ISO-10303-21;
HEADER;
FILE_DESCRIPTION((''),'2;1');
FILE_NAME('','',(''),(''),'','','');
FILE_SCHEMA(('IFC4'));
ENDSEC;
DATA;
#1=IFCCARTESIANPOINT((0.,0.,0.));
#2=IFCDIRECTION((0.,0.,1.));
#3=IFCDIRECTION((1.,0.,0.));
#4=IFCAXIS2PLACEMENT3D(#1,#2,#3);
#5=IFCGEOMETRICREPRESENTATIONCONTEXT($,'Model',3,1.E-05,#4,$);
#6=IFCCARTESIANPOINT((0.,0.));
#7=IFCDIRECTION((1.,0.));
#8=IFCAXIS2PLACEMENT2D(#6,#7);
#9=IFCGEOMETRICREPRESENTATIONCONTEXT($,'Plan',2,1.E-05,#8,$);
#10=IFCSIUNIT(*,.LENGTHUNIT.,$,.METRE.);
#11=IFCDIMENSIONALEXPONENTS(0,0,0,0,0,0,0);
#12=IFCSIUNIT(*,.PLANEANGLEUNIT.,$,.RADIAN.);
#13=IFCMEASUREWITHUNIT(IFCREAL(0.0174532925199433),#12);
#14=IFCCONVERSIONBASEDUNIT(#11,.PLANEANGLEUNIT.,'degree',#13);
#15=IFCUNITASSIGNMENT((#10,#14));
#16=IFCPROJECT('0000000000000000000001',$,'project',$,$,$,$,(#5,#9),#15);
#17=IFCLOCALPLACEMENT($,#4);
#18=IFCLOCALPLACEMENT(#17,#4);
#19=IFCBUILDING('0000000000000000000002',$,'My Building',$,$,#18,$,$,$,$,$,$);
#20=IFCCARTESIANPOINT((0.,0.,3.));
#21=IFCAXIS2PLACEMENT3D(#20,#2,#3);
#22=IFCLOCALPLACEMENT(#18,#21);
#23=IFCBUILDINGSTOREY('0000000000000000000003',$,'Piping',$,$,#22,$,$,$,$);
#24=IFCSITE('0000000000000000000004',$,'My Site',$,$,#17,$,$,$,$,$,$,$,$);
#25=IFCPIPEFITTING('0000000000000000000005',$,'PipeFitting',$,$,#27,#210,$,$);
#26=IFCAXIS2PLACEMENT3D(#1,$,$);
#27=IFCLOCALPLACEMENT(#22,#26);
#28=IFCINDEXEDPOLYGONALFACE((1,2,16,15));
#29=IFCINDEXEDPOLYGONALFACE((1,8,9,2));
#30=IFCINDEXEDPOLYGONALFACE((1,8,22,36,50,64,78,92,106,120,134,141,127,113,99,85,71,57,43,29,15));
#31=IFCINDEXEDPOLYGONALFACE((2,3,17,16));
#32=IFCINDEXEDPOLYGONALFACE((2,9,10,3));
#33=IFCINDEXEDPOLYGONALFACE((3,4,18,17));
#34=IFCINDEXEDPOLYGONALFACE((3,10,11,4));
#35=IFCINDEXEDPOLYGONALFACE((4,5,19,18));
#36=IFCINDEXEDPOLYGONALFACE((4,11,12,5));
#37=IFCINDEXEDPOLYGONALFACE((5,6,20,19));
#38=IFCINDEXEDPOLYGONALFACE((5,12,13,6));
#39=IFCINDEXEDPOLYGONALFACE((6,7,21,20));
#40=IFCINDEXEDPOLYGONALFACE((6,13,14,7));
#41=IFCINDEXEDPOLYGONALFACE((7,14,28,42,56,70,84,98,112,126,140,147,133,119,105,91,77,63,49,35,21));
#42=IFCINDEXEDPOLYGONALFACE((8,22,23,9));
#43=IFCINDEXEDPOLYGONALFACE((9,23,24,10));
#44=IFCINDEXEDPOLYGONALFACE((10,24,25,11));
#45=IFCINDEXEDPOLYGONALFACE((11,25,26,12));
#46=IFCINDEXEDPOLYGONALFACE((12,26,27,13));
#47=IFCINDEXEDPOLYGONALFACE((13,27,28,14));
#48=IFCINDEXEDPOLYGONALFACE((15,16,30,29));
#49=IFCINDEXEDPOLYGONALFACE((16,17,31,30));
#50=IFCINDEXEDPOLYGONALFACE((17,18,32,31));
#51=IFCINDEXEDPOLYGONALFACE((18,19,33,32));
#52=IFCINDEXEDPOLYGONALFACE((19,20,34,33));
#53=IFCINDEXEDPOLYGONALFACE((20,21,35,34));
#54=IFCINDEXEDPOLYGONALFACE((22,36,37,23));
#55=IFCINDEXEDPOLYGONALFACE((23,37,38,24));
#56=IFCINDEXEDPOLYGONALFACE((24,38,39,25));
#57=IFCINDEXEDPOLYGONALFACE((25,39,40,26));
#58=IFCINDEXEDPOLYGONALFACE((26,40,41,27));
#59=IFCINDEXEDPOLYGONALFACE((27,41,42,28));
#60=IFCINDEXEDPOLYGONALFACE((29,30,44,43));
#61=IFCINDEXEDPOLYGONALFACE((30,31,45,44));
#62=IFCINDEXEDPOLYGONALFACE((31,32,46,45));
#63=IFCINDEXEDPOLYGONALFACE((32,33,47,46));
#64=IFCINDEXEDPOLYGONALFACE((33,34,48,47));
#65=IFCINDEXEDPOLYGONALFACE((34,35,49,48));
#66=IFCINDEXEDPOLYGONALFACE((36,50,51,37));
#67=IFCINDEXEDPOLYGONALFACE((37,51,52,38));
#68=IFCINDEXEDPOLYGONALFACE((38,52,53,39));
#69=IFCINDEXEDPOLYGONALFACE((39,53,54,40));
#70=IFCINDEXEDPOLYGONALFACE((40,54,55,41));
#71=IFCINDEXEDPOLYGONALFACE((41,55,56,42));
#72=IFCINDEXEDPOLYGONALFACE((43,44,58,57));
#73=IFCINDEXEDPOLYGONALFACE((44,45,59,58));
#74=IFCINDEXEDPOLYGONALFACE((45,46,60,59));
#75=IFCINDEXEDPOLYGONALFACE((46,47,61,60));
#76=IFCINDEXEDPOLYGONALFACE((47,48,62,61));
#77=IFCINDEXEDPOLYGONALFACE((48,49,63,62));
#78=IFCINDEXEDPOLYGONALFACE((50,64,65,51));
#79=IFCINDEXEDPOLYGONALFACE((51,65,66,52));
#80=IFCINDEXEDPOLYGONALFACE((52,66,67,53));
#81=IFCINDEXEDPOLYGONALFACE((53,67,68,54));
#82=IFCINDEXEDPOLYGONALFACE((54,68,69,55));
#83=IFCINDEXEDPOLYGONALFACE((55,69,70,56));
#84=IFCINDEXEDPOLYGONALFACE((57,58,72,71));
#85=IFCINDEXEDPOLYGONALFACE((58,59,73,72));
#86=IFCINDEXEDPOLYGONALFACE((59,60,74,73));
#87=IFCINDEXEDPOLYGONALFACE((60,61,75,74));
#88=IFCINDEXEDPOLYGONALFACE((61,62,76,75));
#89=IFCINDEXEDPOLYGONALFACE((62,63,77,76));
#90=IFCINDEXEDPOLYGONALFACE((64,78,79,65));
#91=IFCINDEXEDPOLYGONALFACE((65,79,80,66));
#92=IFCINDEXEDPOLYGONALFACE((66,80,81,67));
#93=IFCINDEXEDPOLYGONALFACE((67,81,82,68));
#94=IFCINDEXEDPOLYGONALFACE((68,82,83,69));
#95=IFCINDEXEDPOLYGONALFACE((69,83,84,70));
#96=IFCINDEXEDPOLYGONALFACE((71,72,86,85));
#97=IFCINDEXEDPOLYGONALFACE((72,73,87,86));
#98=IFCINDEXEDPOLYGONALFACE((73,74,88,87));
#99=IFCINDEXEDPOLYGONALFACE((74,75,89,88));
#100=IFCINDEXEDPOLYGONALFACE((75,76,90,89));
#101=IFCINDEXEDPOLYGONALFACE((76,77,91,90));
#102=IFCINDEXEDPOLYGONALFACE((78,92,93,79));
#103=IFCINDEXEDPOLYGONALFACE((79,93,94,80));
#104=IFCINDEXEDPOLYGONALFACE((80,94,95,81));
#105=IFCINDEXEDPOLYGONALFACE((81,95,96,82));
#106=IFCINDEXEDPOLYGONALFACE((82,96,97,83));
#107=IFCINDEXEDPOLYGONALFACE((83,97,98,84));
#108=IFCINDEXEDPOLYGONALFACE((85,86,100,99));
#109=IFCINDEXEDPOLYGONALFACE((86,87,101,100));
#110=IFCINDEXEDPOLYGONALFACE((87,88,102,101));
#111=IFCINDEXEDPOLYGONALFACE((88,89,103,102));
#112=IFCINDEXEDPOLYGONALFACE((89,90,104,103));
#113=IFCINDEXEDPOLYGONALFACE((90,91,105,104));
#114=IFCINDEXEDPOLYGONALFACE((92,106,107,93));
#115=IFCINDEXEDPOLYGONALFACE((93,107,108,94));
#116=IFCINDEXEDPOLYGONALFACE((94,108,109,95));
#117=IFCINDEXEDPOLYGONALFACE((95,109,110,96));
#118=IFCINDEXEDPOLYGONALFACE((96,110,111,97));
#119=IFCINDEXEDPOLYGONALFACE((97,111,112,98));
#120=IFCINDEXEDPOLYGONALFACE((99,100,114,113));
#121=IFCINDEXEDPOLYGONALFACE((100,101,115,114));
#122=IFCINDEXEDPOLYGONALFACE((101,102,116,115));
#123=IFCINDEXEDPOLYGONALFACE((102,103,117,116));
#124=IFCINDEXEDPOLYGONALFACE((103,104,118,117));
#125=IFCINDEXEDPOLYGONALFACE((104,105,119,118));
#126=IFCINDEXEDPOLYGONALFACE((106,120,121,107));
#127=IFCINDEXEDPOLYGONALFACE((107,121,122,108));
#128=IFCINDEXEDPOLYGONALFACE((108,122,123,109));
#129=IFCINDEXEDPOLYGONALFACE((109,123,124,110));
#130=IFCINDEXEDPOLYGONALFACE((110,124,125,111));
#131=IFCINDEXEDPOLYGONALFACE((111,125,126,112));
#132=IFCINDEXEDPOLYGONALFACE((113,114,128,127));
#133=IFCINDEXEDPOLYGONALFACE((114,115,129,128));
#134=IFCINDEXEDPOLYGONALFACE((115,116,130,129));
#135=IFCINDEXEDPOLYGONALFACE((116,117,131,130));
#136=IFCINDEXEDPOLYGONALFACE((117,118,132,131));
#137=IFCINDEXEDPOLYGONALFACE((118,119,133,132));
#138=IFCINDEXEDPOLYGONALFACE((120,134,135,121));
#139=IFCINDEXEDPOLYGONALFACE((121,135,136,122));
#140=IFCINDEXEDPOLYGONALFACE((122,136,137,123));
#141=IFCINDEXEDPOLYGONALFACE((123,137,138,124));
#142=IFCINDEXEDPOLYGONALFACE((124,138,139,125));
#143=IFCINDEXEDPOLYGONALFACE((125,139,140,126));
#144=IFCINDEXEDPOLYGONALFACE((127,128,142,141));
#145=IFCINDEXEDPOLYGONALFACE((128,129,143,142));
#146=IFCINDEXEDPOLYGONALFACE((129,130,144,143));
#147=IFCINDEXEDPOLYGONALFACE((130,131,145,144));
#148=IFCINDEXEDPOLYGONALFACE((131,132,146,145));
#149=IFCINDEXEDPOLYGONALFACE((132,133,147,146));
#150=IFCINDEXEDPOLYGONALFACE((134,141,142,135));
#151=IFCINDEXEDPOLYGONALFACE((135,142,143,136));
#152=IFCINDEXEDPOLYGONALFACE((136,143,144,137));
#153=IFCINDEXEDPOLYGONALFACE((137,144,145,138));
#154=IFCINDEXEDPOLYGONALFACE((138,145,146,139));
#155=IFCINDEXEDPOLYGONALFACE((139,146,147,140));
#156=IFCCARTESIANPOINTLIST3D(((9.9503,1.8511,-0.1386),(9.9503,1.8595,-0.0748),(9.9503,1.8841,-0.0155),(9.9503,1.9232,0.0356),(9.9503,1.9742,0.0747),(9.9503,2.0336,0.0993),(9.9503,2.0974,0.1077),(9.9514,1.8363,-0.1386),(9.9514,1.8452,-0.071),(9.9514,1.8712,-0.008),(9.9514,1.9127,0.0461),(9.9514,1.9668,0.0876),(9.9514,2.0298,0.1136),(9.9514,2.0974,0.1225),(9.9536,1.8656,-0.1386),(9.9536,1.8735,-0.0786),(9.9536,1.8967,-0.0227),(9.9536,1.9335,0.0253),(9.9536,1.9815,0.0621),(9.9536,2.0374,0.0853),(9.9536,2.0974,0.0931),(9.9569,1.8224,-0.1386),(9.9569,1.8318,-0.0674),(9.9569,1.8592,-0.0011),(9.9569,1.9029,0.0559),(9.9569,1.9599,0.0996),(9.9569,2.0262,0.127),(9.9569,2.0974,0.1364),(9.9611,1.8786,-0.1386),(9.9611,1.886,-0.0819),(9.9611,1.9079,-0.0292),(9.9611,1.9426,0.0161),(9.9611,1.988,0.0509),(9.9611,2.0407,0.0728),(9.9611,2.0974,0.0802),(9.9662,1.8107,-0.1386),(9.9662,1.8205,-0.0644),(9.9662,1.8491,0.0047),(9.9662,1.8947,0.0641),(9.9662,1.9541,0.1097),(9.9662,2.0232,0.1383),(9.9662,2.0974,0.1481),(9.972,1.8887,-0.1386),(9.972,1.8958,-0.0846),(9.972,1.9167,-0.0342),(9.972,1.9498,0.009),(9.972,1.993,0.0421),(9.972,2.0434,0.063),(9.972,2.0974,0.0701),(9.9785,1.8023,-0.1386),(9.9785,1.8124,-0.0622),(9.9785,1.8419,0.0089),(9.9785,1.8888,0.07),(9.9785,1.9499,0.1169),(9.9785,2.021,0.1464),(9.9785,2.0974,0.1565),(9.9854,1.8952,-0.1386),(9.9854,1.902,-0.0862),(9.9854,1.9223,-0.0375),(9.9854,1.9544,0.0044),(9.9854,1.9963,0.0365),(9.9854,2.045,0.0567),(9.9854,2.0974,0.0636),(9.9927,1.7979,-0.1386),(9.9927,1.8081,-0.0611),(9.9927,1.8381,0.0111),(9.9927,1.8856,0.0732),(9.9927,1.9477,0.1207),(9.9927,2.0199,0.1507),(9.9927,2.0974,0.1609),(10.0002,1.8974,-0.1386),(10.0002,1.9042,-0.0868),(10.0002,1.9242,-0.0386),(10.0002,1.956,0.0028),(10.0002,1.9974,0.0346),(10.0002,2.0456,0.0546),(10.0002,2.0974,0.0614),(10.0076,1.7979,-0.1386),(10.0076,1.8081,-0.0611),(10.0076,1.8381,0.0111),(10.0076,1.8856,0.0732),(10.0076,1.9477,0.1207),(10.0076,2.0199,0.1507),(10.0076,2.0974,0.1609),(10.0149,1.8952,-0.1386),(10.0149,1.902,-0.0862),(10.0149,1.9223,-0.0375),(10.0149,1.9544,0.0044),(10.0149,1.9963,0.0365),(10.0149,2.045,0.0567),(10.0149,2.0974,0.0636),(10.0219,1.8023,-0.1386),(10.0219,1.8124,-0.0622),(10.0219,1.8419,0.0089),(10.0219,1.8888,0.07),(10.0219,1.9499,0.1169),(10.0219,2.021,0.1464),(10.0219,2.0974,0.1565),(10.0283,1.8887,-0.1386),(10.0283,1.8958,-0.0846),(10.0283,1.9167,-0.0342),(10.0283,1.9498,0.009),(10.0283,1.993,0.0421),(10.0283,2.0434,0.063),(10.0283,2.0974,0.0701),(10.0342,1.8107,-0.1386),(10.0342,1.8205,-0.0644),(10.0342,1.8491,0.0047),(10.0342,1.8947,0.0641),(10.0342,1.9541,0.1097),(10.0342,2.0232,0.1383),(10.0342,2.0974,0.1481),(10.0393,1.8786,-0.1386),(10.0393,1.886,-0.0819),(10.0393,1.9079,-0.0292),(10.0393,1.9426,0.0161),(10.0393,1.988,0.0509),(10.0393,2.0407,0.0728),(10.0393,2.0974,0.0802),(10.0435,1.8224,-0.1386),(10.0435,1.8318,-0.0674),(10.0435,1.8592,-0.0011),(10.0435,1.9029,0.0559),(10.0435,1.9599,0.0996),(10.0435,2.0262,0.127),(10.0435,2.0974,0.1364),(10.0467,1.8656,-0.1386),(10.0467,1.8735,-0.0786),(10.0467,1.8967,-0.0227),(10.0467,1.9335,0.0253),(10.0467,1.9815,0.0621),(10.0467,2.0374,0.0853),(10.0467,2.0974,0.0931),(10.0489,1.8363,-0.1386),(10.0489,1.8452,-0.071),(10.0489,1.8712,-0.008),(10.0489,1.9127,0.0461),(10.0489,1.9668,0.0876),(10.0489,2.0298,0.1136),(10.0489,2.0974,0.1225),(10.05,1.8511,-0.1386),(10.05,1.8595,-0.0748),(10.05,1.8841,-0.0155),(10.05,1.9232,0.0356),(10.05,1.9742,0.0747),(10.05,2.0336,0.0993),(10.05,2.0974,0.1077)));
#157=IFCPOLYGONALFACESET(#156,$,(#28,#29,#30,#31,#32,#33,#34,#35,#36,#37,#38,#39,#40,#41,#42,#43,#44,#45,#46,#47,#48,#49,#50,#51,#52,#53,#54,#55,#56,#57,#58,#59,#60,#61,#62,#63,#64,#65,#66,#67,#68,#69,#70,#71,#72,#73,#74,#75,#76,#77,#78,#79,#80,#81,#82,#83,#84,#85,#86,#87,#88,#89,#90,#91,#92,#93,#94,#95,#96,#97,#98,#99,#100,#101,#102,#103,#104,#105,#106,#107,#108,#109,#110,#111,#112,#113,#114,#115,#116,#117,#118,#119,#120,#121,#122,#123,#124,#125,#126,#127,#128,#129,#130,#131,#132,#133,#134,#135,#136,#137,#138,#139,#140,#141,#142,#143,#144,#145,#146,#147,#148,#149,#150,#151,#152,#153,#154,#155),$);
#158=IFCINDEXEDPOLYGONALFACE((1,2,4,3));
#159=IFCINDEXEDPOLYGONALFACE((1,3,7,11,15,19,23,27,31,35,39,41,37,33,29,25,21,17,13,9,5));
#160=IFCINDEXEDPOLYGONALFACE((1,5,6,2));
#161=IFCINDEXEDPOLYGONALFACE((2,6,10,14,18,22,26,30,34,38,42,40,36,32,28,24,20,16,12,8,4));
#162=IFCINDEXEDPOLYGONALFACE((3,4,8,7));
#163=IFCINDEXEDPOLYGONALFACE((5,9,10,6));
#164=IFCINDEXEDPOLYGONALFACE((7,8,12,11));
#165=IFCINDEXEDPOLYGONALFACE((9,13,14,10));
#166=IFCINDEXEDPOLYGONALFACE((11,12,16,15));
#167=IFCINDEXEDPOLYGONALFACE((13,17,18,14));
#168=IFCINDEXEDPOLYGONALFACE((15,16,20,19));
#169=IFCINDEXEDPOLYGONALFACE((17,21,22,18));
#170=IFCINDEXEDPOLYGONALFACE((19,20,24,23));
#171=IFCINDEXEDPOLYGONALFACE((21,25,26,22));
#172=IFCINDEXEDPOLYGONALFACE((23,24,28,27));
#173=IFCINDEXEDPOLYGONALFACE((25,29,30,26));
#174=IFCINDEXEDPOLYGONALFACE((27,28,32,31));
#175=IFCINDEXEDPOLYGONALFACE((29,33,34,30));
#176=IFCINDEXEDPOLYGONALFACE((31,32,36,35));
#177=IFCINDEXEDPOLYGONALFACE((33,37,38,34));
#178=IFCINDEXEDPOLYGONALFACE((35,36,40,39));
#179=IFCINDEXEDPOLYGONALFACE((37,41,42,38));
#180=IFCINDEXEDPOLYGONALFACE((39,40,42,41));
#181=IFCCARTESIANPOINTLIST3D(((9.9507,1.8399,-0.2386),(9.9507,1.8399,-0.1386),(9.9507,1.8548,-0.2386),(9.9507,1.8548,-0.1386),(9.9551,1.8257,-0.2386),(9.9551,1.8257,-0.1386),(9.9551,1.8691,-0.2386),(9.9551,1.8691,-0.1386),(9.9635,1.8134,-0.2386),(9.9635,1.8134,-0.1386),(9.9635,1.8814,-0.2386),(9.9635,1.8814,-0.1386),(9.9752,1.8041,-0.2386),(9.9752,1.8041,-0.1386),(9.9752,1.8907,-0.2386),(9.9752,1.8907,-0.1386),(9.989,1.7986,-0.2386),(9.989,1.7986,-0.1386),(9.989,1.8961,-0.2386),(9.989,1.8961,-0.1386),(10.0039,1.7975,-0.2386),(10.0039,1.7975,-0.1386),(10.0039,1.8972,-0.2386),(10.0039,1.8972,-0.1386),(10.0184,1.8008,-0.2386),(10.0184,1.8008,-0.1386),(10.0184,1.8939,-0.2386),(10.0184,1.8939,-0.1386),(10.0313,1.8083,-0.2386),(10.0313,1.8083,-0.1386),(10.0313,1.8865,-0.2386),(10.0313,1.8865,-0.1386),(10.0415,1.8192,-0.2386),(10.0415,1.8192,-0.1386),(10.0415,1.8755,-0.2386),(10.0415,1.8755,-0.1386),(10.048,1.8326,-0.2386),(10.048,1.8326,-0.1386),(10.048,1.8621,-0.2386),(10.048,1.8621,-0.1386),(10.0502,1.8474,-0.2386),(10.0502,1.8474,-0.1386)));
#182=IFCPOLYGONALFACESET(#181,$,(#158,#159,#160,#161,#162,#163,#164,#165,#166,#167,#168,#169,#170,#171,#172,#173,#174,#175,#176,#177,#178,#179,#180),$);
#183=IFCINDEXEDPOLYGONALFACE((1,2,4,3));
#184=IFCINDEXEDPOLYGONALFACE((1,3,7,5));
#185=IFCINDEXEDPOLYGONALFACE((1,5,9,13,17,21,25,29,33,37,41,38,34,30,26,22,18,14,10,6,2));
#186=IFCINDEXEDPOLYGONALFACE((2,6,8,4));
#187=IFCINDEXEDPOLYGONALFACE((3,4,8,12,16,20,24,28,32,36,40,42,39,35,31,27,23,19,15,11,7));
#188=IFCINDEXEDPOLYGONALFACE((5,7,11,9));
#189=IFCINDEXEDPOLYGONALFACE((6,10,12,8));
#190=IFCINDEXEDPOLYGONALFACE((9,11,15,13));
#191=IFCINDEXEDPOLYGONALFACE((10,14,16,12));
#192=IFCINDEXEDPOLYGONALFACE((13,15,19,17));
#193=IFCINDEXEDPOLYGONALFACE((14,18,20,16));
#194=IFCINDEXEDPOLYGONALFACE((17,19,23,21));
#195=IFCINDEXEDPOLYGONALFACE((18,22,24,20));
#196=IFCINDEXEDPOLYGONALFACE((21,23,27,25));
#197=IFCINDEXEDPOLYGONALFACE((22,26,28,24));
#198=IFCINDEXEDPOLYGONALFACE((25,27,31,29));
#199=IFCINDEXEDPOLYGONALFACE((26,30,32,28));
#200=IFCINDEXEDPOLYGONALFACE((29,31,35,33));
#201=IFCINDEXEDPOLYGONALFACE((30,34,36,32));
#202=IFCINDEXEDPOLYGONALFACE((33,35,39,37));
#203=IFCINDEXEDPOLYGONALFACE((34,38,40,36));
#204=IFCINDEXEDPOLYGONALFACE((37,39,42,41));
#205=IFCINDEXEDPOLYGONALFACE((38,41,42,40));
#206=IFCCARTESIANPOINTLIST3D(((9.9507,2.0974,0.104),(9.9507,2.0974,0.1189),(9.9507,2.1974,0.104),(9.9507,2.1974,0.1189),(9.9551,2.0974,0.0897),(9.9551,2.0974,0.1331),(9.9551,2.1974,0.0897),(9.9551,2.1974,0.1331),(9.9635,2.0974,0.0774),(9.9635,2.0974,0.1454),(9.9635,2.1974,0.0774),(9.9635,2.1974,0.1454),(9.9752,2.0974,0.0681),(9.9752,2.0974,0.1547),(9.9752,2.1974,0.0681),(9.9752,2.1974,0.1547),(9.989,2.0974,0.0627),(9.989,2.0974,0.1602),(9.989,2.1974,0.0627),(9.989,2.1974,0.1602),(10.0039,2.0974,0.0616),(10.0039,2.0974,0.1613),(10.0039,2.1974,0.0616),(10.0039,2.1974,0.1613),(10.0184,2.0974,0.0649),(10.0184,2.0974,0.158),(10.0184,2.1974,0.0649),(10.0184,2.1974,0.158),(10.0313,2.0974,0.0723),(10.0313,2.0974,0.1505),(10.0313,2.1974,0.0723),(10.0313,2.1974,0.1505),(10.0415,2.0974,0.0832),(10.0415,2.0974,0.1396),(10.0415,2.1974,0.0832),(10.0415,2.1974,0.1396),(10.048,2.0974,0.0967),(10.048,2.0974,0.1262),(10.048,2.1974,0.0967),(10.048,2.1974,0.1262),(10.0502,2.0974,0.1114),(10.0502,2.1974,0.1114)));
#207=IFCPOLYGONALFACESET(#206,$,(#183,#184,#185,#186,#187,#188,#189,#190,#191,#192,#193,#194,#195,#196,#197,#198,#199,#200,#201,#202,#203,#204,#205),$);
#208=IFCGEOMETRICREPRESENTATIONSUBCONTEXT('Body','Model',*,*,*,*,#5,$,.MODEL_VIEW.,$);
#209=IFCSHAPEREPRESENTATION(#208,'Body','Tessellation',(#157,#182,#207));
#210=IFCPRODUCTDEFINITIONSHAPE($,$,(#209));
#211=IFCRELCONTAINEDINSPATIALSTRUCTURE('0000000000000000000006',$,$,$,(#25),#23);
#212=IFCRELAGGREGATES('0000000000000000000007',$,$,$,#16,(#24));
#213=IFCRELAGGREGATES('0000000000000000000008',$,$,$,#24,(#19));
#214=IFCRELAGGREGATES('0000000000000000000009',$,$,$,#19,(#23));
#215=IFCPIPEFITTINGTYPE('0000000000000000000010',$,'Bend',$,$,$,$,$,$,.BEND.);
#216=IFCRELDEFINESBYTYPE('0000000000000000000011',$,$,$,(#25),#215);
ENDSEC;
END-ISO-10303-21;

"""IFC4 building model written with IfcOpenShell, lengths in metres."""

from ifc_helpers import new_model, entity, si_unit, converted_unit, frame, origin_with_axes, origin_2d_with_axis, place, context, subcontext, project, spatial, circle, extrude, source, transform, mapped, type_object, type_shapes, element, save


model = new_model("IFC4")

# Units and contexts
model_context = context("Model", 3, precision=1e-05, world=origin_with_axes())
plan_context = context("Plan", 2, precision=1e-05, world=origin_2d_with_axis())
body_context = subcontext(model_context, "Body", "Model", "MODEL_VIEW")
ifc_project = project(units=[si_unit("LENGTHUNIT", "METRE"), converted_unit("PLANEANGLEUNIT", "degree", entity("IfcReal", 0.0174532925199433), si_unit("PLANEANGLEUNIT", "RADIAN"), dimensions=[0, 0, 0, 0, 0, 0, 0])], contexts=[model_context, plan_context])

# Site, building, storey
site_placement = place(None, origin_with_axes())
site = spatial("IfcSite", under=ifc_project, at=site_placement, Name="My Site")
building_placement = place(site_placement, origin_with_axes())
building = spatial("IfcBuilding", under=site, at=building_placement, Name="My Building")
storey_placement = place(building_placement, frame((0.0, 0.0, 3.0), z_axis=(0.0, 0.0, 1.0), x_axis=(1.0, 0.0, 0.0)))
storey = spatial("IfcBuildingStorey", under=building, at=storey_placement, Name="Piping")

# Pipe fitting
pipe_fitting_type_1 = type_object("IfcPipeFittingType", Name="Bend", PredefinedType="BEND")
shared_shape = source(origin_with_axes(), body_context, "Body", "SolidModel", [
    entity("IfcSweptDiskSolid", entity("IfcIndexedPolyCurve", entity("IfcCartesianPointList3D", [[0.0, 0.0, -0.1], [0.0, -0.0732, -0.2768], [0.0, -0.25, -0.35]]), [entity("IfcArcIndex", [1, 2, 3])]), 0.05),
    extrude(circle(Radius=0.05), origin_with_axes(), (0.0, 0.0, -1.0), 0.1),
    extrude(circle(Radius=0.05), frame((0.0, -0.25, -0.35), z_axis=(0.0, -1.0, 0.0), x_axis=(1.0, 0.0, 0.0)), (0.0, 0.0, 1.0), 0.1),
])
type_shapes(pipe_fitting_type_1, [shared_shape])
for number, where, z_axis, x_axis, name in (
    (1, (10.0002, 1.8474, -0.2386), (0.0, 0.0, -1.0), (1.0, 0.0, 0.0), "PipeFitting"),
):
    element("IfcPipeFitting", number, at=place(storey_placement, frame(where, z_axis=z_axis, x_axis=x_axis)), inside=storey, type_object=pipe_fitting_type_1, Name=name, context=body_context, shape_type="MappedRepresentation", body=[
        mapped(shared_shape, transform((0.0, 0.0, 0.0), x_axis=(1.0, 0.0, 0.0), y_axis=(0.0, 1.0, 0.0), z_axis=(0.0, 0.0, 1.0), scale=1.0)),
    ])

save(model, "model.ifc")
